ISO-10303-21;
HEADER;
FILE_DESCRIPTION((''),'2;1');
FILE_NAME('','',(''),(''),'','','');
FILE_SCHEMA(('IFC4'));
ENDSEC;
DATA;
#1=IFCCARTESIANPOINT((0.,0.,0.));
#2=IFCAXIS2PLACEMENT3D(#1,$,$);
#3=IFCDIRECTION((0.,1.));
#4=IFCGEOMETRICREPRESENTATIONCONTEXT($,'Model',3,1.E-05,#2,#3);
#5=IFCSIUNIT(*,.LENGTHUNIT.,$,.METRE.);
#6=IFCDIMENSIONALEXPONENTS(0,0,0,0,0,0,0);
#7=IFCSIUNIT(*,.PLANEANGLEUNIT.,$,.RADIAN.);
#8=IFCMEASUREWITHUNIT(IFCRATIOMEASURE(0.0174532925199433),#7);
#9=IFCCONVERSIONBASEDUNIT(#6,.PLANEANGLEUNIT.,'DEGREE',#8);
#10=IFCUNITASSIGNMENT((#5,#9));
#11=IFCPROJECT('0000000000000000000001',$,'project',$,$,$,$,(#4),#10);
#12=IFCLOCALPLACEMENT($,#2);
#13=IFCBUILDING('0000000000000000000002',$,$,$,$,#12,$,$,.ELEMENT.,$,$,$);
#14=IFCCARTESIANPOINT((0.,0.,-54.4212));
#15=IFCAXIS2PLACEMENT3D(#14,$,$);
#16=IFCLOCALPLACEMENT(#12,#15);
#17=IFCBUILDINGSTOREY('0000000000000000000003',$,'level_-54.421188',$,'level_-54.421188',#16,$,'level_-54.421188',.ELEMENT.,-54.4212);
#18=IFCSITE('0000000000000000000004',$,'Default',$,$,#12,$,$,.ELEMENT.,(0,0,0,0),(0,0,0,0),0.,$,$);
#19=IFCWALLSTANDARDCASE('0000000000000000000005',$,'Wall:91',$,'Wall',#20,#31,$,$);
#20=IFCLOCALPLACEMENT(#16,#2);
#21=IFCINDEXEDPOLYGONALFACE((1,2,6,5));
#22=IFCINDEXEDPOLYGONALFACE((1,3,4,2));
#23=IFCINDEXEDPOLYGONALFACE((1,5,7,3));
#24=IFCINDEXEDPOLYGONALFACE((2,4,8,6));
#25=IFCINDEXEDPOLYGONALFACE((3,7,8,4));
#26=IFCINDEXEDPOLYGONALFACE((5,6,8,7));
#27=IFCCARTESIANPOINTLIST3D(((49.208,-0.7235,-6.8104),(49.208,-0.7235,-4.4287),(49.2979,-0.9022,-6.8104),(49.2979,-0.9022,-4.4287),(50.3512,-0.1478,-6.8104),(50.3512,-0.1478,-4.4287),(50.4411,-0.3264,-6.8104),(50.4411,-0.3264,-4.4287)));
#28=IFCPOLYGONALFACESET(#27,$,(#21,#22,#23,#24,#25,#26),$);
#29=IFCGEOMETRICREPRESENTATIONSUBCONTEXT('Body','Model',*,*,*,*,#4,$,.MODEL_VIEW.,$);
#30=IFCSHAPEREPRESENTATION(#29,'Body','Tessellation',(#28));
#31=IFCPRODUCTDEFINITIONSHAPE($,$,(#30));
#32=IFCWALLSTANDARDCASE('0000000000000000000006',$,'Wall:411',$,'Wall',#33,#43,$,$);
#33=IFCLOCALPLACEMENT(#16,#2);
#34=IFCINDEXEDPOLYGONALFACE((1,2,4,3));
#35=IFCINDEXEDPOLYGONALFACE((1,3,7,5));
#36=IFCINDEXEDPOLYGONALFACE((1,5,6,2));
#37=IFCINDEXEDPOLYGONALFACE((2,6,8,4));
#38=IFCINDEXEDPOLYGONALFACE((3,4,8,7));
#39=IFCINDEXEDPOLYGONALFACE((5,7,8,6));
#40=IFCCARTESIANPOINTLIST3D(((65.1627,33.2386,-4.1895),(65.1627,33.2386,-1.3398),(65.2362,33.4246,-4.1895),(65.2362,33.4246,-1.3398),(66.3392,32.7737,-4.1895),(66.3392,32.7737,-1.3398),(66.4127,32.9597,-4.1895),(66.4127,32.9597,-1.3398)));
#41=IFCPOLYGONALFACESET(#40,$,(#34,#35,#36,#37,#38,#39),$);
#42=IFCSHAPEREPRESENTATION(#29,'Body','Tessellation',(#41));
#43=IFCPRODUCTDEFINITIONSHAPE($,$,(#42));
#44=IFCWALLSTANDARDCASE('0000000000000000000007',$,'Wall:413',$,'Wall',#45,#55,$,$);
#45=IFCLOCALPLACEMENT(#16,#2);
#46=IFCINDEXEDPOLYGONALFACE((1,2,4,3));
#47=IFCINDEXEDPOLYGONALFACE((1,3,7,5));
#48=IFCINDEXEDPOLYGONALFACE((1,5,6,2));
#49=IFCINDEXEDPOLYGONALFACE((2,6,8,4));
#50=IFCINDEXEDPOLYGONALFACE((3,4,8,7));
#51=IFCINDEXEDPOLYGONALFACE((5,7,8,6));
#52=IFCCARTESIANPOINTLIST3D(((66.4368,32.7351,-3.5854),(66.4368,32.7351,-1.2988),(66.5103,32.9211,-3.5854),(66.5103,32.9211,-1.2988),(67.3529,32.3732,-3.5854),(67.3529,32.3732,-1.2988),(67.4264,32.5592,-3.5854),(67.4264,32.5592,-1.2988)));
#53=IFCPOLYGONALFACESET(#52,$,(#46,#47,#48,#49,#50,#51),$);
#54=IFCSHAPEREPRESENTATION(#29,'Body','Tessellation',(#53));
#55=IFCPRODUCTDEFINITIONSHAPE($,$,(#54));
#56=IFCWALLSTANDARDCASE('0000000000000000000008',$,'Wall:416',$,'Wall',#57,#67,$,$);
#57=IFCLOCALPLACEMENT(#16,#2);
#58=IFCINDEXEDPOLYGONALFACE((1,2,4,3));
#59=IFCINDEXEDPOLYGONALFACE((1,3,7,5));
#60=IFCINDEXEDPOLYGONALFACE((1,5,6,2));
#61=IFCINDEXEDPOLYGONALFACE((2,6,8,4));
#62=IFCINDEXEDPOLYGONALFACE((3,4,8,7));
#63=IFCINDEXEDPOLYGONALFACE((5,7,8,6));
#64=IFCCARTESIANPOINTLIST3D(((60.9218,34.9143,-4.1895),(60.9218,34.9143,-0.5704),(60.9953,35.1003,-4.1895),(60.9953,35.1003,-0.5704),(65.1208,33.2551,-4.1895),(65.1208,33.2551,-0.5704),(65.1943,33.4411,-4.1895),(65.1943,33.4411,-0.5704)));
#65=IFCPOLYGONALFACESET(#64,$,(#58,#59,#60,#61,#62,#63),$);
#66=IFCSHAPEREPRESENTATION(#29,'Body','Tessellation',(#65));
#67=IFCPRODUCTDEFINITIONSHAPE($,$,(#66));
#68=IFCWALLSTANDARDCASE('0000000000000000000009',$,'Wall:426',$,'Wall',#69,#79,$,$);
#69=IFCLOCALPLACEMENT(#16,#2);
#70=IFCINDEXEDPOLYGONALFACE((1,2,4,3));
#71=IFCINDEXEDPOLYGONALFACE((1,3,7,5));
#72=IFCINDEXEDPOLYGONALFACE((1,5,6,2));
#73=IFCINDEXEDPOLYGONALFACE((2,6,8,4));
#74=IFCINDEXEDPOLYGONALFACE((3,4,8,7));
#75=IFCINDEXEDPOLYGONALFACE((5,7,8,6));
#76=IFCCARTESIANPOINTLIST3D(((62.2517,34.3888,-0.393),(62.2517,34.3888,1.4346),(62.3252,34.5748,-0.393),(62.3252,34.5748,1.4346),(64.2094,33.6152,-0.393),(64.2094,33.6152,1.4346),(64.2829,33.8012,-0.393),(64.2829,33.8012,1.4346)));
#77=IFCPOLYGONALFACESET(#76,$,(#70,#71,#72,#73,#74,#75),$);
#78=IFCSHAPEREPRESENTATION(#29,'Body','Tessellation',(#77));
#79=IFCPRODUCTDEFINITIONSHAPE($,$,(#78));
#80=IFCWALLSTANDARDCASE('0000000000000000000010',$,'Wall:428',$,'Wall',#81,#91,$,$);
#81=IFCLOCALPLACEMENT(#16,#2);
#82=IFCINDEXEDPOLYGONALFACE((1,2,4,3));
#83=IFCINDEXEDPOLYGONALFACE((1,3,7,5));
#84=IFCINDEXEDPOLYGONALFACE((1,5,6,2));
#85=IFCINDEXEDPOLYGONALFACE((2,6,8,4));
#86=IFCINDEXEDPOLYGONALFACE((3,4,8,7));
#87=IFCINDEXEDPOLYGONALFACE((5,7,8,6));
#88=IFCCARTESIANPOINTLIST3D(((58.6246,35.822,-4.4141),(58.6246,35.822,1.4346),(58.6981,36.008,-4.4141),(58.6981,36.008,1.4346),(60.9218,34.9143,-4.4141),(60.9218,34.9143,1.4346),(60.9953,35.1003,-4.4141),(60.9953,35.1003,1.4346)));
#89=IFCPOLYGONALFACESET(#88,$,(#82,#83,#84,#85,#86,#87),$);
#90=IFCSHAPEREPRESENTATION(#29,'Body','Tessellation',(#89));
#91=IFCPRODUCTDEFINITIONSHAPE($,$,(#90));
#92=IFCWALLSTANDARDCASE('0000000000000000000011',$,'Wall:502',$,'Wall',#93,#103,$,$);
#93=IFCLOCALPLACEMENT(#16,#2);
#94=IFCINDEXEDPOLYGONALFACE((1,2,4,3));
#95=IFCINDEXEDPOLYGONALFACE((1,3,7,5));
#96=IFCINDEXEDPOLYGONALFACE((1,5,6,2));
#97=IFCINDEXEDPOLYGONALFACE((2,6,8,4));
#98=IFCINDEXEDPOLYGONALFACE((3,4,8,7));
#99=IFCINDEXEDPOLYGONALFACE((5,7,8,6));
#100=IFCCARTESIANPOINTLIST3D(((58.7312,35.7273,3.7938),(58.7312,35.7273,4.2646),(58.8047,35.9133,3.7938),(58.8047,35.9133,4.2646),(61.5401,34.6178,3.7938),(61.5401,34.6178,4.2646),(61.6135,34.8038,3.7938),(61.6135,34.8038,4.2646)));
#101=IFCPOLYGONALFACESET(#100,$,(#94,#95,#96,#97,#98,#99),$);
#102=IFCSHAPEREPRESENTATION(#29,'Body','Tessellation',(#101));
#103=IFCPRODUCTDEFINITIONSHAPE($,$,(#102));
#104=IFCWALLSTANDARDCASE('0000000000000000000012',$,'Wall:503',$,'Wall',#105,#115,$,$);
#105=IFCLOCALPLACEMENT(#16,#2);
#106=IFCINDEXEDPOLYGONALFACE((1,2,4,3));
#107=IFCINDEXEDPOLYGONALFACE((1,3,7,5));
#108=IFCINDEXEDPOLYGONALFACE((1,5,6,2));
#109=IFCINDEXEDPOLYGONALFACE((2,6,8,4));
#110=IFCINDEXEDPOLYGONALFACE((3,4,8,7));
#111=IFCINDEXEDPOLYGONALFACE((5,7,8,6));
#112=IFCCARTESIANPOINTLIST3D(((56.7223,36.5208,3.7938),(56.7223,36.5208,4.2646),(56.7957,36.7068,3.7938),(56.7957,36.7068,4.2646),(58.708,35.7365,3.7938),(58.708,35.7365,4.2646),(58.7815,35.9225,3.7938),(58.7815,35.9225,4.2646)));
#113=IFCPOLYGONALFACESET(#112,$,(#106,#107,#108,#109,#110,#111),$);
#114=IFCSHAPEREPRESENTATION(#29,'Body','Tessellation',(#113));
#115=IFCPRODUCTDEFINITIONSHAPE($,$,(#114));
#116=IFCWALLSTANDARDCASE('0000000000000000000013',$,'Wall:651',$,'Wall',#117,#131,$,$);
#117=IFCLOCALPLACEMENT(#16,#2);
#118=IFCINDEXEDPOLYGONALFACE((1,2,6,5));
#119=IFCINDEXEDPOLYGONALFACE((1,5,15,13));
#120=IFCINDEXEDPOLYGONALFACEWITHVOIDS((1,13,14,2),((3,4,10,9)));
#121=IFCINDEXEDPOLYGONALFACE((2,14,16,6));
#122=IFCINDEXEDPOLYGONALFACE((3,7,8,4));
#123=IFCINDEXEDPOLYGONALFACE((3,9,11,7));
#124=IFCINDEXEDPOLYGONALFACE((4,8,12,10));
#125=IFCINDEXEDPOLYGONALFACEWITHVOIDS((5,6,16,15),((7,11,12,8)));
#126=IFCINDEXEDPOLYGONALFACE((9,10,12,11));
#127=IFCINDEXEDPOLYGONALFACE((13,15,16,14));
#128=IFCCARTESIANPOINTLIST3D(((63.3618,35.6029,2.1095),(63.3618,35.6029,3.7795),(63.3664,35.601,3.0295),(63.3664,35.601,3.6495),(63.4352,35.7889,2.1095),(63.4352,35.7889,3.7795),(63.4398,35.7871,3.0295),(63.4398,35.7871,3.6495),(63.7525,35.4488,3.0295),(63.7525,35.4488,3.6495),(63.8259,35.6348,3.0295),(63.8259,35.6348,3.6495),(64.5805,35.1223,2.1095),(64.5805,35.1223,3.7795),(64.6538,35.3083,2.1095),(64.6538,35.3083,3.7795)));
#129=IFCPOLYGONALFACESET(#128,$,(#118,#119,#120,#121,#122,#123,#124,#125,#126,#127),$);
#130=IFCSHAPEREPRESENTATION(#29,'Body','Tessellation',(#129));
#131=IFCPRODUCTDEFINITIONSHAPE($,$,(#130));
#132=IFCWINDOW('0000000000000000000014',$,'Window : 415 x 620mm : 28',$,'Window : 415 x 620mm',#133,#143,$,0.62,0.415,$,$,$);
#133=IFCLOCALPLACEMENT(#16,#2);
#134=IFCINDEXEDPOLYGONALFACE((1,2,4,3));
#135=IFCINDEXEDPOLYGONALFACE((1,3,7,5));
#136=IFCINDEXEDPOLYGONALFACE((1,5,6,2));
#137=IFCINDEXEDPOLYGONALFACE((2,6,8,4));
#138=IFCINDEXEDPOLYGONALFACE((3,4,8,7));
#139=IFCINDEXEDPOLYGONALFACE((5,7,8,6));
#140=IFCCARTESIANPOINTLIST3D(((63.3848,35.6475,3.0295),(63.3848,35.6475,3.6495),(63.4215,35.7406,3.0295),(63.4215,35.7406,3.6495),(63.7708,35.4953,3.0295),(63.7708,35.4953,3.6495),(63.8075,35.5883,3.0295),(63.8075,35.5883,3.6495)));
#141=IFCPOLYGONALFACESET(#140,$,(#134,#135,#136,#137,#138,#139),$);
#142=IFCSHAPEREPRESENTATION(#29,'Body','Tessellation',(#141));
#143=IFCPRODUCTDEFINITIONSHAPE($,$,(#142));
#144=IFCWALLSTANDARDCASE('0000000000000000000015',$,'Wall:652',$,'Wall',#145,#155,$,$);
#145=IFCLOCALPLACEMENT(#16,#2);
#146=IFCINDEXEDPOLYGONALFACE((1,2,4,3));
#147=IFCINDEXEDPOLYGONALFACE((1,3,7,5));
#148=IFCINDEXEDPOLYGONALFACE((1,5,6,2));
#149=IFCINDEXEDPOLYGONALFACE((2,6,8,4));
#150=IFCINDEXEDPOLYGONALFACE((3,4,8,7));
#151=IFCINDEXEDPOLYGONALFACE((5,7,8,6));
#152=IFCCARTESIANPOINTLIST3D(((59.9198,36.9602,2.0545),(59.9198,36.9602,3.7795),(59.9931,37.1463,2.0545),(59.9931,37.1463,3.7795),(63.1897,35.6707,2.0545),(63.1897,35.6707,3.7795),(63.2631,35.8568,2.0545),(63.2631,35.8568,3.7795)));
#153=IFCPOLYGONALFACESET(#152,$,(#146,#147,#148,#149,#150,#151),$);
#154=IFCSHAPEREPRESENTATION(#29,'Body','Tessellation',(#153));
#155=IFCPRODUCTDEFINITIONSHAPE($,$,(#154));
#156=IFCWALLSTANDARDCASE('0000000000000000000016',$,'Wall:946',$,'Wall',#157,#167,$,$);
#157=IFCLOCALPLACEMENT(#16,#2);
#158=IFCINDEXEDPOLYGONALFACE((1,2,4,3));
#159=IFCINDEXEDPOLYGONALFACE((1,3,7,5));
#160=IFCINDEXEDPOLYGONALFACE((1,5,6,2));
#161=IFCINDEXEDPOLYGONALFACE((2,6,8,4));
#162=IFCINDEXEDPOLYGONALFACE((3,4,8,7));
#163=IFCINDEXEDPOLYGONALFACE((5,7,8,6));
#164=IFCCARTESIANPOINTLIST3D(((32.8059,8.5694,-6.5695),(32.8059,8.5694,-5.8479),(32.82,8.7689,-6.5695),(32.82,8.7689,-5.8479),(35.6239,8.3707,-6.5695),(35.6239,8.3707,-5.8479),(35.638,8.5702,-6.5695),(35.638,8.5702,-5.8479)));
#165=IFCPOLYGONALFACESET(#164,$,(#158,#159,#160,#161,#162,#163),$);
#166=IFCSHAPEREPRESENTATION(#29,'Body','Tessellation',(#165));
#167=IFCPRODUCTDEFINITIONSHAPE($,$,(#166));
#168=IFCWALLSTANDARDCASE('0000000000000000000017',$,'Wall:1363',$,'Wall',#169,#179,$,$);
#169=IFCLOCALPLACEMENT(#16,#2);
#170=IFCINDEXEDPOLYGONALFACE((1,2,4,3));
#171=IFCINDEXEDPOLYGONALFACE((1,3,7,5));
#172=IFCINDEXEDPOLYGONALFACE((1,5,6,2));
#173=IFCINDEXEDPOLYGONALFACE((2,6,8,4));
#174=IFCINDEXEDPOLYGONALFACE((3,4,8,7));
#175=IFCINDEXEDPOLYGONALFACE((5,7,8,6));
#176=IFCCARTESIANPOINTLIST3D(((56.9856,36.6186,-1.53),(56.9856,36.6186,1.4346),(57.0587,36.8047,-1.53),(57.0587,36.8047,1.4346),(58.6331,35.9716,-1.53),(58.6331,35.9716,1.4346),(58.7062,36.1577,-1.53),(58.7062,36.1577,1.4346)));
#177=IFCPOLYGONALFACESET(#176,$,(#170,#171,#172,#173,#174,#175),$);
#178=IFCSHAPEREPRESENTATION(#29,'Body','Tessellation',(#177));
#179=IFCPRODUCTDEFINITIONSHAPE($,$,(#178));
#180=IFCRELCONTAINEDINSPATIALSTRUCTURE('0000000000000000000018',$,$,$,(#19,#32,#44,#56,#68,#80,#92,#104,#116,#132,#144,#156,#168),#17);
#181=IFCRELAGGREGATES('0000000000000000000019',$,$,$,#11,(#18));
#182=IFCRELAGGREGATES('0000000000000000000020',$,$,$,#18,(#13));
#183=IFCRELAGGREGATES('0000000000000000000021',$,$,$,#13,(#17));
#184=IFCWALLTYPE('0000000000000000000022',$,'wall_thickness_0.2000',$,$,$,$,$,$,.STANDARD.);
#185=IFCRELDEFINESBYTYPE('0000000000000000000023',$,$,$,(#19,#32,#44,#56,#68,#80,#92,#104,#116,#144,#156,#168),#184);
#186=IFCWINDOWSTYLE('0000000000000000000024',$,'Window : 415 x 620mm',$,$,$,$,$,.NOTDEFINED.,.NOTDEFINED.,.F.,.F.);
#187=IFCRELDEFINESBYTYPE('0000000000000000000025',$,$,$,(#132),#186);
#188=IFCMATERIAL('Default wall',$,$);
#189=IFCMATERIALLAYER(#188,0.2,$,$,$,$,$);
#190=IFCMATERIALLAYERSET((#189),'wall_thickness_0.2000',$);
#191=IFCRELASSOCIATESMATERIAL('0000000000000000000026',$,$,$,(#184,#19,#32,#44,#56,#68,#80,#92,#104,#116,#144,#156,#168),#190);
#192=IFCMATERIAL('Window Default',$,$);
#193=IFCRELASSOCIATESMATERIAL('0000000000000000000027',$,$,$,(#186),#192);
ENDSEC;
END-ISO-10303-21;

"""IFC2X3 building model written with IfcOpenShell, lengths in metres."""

from ifc_helpers import new_model, entity, si_unit, converted_unit, direction, frame, frame_2d, origin, origin_2d_with_axis, place, context, subcontext, project, spatial, polyline, rectangle, outline, extrude, source, transform, mapped, material, layer, layer_set, layer_usage, type_object, type_shapes, element, fill, save


model = new_model("IFC2X3")

# Units and contexts
model_context = context("Model", 3, precision=1e-05, world=origin(), true_north=direction((0.0, 1.0)))
body_context = subcontext(model_context, "Body", "Model", "MODEL_VIEW")
ifc_project = project(units=[si_unit("LENGTHUNIT", "METRE"), converted_unit("PLANEANGLEUNIT", "DEGREE", entity("IfcRatioMeasure", 0.0174532925199433), si_unit("PLANEANGLEUNIT", "RADIAN"), dimensions=[0, 0, 0, 0, 0, 0, 0])], contexts=[model_context])

# Site, building, storey
placement_1 = place(None, origin())
site = spatial("IfcSite", under=ifc_project, at=placement_1, Name="Default", CompositionType="ELEMENT", RefLatitude=(0, 0, 0, 0), RefLongitude=(0, 0, 0, 0), RefElevation=0.0)
building = spatial("IfcBuilding", under=site, at=placement_1, CompositionType="ELEMENT")
storey_placement = place(placement_1, frame((0.0, 0.0, -54.4212)))
storey = spatial("IfcBuildingStorey", under=building, at=storey_placement, Name="level_-54.421188", ObjectType="level_-54.421188", LongName="level_-54.421188", CompositionType="ELEMENT", Elevation=-54.4212)

# Walls
ifc_material_1 = material(Name="Default wall")
ifc_layer = layer(ifc_material_1, 0.2)
ifc_layer_set = layer_set([ifc_layer], Name="wall_thickness_0.2000")
ifc_layer_usage = layer_usage(ifc_layer_set, "AXIS2", "POSITIVE", -0.1)
wall_type = type_object("IfcWallType", Name="wall_thickness_0.2000", PredefinedType="STANDARD", material=ifc_layer_set)
placement_2 = place(placement_1, frame((0.0, 0.0, -61.2316)))
wall_1_placement = place(placement_2, frame((50.3962, -0.2371, 0.0), z_axis=(0.0, 0.0, 1.0), x_axis=(-0.893126, -0.449807, 0.0)))
element("IfcWallStandardCase", 1, at=wall_1_placement, inside=storey, type_object=wall_type, material=ifc_layer_usage, Name="Wall:91", ObjectType="Wall", context=body_context, shape_type="SweptSolid", body=[
    extrude(outline(polyline([(1.28, -0.1), (1.28, 0.1), (0.0, 0.1), (0.0, -0.1), (1.28, -0.1)])), origin(), (0.0, 0.0, 1.0), 2.3817),
])
placement_3 = place(placement_1, frame((0.0, 0.0, -58.6107)))
wall_2_placement = place(placement_3, frame((65.1995, 33.3316, 0.0), z_axis=(0.0, 0.0, 1.0), x_axis=(0.930031, -0.36748, 0.0)))
element("IfcWallStandardCase", 2, at=wall_2_placement, inside=storey, type_object=wall_type, material=ifc_layer_usage, Name="Wall:411", ObjectType="Wall", context=body_context, shape_type="SweptSolid", body=[
    extrude(outline(polyline([(1.265, -0.1), (1.265, 0.1), (0.0, 0.1), (0.0, -0.1), (1.265, -0.1)])), origin(), (0.0, 0.0, 1.0), 2.8497),
])
placement_4 = place(placement_1, frame((0.0, 0.0, -58.0066)))
wall_3_placement = place(placement_4, frame((66.4736, 32.8281, 0.0), z_axis=(0.0, 0.0, 1.0), x_axis=(0.930033, -0.367477, 0.0)))
element("IfcWallStandardCase", 3, at=wall_3_placement, inside=storey, type_object=wall_type, material=ifc_layer_usage, Name="Wall:413", ObjectType="Wall", context=body_context, shape_type="SweptSolid", body=[
    extrude(outline(polyline([(0.985, -0.1), (0.985, 0.1), (0.0, 0.1), (0.0, -0.1), (0.985, -0.1)])), origin(), (0.0, 0.0, 1.0), 2.2867),
])
placement_5 = place(placement_1, frame((0.0, 0.0, -58.6107)))
wall_4_placement = place(placement_5, frame((60.9585, 35.0073, 0.0), z_axis=(0.0, 0.0, 1.0), x_axis=(0.930032, -0.367479, 0.0)))
element("IfcWallStandardCase", 4, at=wall_4_placement, inside=storey, type_object=wall_type, material=ifc_layer_usage, Name="Wall:416", ObjectType="Wall", context=body_context, shape_type="SweptSolid", body=[
    extrude(outline(polyline([(4.515, -0.1), (4.515, 0.1), (0.0, 0.1), (0.0, -0.1), (4.515, -0.1)])), origin(), (0.0, 0.0, 1.0), 3.6192),
])
placement_6 = place(placement_1, frame((0.0, 0.0, -54.8142)))
wall_5_placement = place(placement_6, frame((62.2884, 34.4818, 0.0), z_axis=(0.0, 0.0, 1.0), x_axis=(0.930032, -0.367479, 0.0)))
element("IfcWallStandardCase", 5, at=wall_5_placement, inside=storey, type_object=wall_type, material=ifc_layer_usage, Name="Wall:426", ObjectType="Wall", context=body_context, shape_type="SweptSolid", body=[
    extrude(outline(polyline([(2.105, -0.1), (2.105, 0.1), (0.0, 0.1), (0.0, -0.1), (2.105, -0.1)])), origin(), (0.0, 0.0, 1.0), 1.8276),
])
placement_7 = place(placement_1, frame((0.0, 0.0, -58.8353)))
wall_6_placement = place(placement_7, frame((58.6613, 35.915, 0.0), z_axis=(0.0, 0.0, 1.0), x_axis=(0.930031, -0.367481, 0.0)))
element("IfcWallStandardCase", 6, at=wall_6_placement, inside=storey, type_object=wall_type, material=ifc_layer_usage, Name="Wall:428", ObjectType="Wall", context=body_context, shape_type="SweptSolid", body=[
    extrude(outline(polyline([(2.47, -0.1), (2.47, 0.1), (0.0, 0.1), (0.0, -0.1), (2.47, -0.1)])), origin(), (0.0, 0.0, 1.0), 5.8486),
])
placement_8 = place(placement_1, frame((0.0, 0.0, -50.6274)))
wall_7_placement = place(placement_8, frame((58.768, 35.8203, 0.0), z_axis=(0.0, 0.0, 1.0), x_axis=(0.930073, -0.367375, 0.0)))
element("IfcWallStandardCase", 7, at=wall_7_placement, inside=storey, type_object=wall_type, material=ifc_layer_usage, Name="Wall:502", ObjectType="Wall", context=body_context, shape_type="SweptSolid", body=[
    extrude(outline(polyline([(3.02, -0.1), (3.02, 0.1), (0.0, 0.1), (0.0, -0.1), (3.02, -0.1)])), origin(), (0.0, 0.0, 1.0), 0.4708),
])
placement_9 = place(placement_1, frame((0.0, 0.0, -50.6274)))
wall_8_placement = place(placement_9, frame((56.759, 36.6138, 0.0), z_axis=(0.0, 0.0, 1.0), x_axis=(0.930073, -0.367374, 0.0)))
element("IfcWallStandardCase", 8, at=wall_8_placement, inside=storey, type_object=wall_type, material=ifc_layer_usage, Name="Wall:503", ObjectType="Wall", context=body_context, shape_type="SweptSolid", body=[
    extrude(outline(polyline([(2.135, -0.1), (2.135, 0.1), (0.0, 0.1), (0.0, -0.1), (2.135, -0.1)])), origin(), (0.0, 0.0, 1.0), 0.4708),
])

# Wall, opening, window
placement_10 = place(placement_1, frame((0.0, 0.0, -52.3117)))
wall_9_placement = place(placement_10, frame((63.3985, 35.6959, 0.0), z_axis=(0.0, 0.0, 1.0), x_axis=(0.930275, -0.366863, 0.0)))
wall_9 = element("IfcWallStandardCase", 9, at=wall_9_placement, inside=storey, type_object=wall_type, material=ifc_layer_usage, Name="Wall:651", ObjectType="Wall", context=body_context, shape_type="SweptSolid", body=[
    extrude(outline(polyline([(1.31, -0.1), (1.31, 0.1), (0.0, 0.1), (0.0, -0.1), (1.31, -0.1)])), origin(), (0.0, 0.0, 1.0), 1.67),
])
opening_placement = place(wall_9_placement, frame((0.005, -0.1, 0.92)))
opening = element("IfcOpeningElement", 10, at=opening_placement, cuts=wall_9, ObjectType="Opening", context=body_context, shape_type="SweptSolid", body=[
    extrude(rectangle(XDim=0.415, YDim=0.62, at=frame_2d((0.31, 0.2075), x_axis=(0.0, 1.0))), frame((0.0, 0.0, 0.0), z_axis=(0.0, 1.0, 0.0), x_axis=(0.0, 0.0, 1.0)), (0.0, 0.0, 1.0), 0.2),
])
ifc_material_2 = material(Name="Window Default")
window_style = type_object("IfcWindowStyle", Name="Window : 415 x 620mm", ConstructionType="NOTDEFINED", OperationType="NOTDEFINED", ParameterTakesPrecedence=False, Sizeable=False, material=ifc_material_2)
shared_shape = source(origin(), body_context, "Body", "SweptSolid", [
    extrude(rectangle(XDim=0.1, YDim=0.415, at=origin_2d_with_axis()), frame((0.2075, 0.1, 0.0), z_axis=(0.0, 0.0, 1.0), x_axis=(0.0, 1.0, 0.0)), (0.0, 0.0, 1.0), 0.62),
])
type_shapes(window_style, [shared_shape])
window_placement = place(opening_placement, origin())
window = element("IfcWindow", 11, at=window_placement, inside=storey, type_object=window_style, Name="Window : 415 x 620mm : 28", ObjectType="Window : 415 x 620mm", OverallHeight=0.62, OverallWidth=0.415, context=body_context, shape_type="MappedRepresentation", body=[
    mapped(shared_shape, transform((0.0, 0.0, 0.0), scale=1.0)),
])
fill(opening, window)

# Walls
placement_11 = place(placement_1, frame((0.0, 0.0, -52.3667)))
wall_10_placement = place(placement_11, frame((59.9565, 37.0533, 0.0), z_axis=(0.0, 0.0, 1.0), x_axis=(0.930275, -0.366862, 0.0)))
element("IfcWallStandardCase", 12, at=wall_10_placement, inside=storey, type_object=wall_type, material=ifc_layer_usage, Name="Wall:652", ObjectType="Wall", context=body_context, shape_type="SweptSolid", body=[
    extrude(outline(polyline([(3.515, -0.1), (3.515, 0.1), (0.0, 0.1), (0.0, -0.1), (3.515, -0.1)])), origin(), (0.0, 0.0, 1.0), 1.725),
])
placement_12 = place(placement_1, frame((0.0, 0.0, -60.9907)))
wall_11_placement = place(placement_12, frame((32.8129, 8.6692, 0.0), z_axis=(0.0, 0.0, 1.0), x_axis=(0.997523, -0.070337, 0.0)))
element("IfcWallStandardCase", 13, at=wall_11_placement, inside=storey, type_object=wall_type, material=ifc_layer_usage, Name="Wall:946", ObjectType="Wall", context=body_context, shape_type="SweptSolid", body=[
    extrude(outline(polyline([(2.825, -0.1), (2.825, 0.1), (0.0, 0.1), (0.0, -0.1), (2.825, -0.1)])), origin(), (0.0, 0.0, 1.0), 0.7215),
])
placement_13 = place(placement_1, frame((0.0, 0.0, -55.9512)))
wall_12_placement = place(placement_13, frame((58.6697, 36.0646, 0.0), z_axis=(0.0, 0.0, 1.0), x_axis=(-0.930792, 0.365549, 0.0)))
element("IfcWallStandardCase", 14, at=wall_12_placement, inside=storey, type_object=wall_type, material=ifc_layer_usage, Name="Wall:1363", ObjectType="Wall", context=body_context, shape_type="SweptSolid", body=[
    extrude(outline(polyline([(1.77, -0.1), (1.77, 0.1), (0.0, 0.1), (0.0, -0.1), (1.77, -0.1)])), origin(), (0.0, 0.0, 1.0), 2.9645),
])

save(model, "model.ifc")
